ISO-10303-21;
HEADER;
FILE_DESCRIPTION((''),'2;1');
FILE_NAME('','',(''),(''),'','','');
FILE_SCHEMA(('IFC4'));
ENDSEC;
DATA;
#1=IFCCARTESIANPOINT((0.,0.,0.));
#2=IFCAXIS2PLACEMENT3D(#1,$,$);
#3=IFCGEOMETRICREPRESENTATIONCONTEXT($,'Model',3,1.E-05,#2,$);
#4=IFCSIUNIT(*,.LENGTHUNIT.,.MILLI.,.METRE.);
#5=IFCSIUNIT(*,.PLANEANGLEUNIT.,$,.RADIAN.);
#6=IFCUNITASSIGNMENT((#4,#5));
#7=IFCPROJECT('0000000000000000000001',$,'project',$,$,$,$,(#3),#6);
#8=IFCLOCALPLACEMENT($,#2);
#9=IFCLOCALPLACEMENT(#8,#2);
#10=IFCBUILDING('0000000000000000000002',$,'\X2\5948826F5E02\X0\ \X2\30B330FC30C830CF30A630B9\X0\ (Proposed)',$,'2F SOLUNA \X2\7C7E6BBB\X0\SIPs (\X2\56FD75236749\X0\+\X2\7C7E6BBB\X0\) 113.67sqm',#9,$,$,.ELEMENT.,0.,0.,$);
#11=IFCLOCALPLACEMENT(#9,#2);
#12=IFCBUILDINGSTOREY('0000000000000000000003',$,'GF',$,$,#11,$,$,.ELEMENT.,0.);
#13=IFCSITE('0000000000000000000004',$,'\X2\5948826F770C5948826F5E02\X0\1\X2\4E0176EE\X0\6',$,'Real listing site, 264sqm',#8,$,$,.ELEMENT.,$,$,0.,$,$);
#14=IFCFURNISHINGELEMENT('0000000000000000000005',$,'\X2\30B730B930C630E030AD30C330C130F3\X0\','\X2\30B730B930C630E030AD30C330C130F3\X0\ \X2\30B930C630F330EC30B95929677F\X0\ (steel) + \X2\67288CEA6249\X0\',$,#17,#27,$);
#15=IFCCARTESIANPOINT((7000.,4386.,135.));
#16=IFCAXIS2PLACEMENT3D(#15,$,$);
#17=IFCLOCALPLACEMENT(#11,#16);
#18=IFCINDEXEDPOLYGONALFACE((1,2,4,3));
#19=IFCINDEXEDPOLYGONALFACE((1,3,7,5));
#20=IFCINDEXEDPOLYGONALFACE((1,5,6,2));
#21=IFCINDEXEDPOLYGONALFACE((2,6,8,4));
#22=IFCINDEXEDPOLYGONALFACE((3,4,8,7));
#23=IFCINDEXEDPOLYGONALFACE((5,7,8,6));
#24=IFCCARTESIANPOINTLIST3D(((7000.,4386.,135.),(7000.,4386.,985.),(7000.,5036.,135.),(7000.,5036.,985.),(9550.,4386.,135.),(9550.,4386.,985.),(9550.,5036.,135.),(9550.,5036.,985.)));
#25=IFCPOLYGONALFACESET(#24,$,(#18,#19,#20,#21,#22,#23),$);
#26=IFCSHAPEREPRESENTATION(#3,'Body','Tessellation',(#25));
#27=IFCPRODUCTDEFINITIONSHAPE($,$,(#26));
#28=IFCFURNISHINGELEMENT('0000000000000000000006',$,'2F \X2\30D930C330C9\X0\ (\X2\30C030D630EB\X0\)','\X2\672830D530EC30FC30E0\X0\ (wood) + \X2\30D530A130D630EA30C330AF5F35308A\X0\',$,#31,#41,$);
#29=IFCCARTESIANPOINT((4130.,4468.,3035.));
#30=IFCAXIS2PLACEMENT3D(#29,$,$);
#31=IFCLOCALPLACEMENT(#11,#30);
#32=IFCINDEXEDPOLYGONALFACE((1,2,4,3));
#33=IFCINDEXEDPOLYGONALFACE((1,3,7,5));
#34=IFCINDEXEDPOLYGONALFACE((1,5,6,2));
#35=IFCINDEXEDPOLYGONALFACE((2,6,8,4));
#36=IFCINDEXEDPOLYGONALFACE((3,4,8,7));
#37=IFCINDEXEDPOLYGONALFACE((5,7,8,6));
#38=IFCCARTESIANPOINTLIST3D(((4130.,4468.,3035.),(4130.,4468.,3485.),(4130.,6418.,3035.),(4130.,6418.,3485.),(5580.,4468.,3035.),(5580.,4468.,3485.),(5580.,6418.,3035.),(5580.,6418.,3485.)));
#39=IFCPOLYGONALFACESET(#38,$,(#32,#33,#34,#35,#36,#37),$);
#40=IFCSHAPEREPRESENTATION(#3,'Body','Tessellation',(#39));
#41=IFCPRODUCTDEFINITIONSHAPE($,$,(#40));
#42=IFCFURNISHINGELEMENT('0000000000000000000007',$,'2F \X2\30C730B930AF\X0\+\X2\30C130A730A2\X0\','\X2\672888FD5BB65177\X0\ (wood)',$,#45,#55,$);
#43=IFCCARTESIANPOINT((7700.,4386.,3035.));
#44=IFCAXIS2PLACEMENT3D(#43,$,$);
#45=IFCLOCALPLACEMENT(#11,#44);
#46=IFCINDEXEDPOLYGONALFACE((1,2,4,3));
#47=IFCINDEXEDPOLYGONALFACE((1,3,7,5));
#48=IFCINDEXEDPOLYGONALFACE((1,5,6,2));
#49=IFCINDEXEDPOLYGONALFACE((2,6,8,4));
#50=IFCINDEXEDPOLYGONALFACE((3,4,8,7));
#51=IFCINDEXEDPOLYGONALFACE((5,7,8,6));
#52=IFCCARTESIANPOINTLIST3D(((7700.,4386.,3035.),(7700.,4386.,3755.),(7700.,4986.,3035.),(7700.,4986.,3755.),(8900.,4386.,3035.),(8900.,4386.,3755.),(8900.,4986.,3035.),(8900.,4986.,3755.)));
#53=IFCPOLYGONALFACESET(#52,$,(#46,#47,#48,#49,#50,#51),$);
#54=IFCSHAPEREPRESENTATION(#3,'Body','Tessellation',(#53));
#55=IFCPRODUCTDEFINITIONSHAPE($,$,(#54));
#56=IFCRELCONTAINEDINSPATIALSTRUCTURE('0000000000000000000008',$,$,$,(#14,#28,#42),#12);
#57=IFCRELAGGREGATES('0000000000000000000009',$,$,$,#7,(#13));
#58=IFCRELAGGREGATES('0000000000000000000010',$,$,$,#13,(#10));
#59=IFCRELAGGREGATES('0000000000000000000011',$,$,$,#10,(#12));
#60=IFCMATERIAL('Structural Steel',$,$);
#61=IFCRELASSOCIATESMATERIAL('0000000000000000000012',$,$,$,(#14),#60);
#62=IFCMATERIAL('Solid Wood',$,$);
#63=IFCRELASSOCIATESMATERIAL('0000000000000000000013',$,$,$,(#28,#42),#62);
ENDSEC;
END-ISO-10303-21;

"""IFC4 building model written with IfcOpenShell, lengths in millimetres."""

from ifc_helpers import new_model, si_unit, frame, frame_2d, origin, place, context, project, spatial, rectangle, extrude, material, element, save


model = new_model("IFC4")

# Units and contexts
model_context = context("Model", 3, precision=1e-05, world=origin())
ifc_project = project(units=[si_unit("LENGTHUNIT", "METRE", prefix="MILLI"), si_unit("PLANEANGLEUNIT", "RADIAN")], contexts=[model_context])

# Site, building, storey
site_placement = place(None, origin())
site = spatial("IfcSite", under=ifc_project, at=site_placement, Name="奈良県奈良市1丁目6", ObjectType="Real listing site, 264sqm", CompositionType="ELEMENT", RefElevation=0.0)
building_placement = place(site_placement, origin())
building = spatial("IfcBuilding", under=site, at=building_placement, Name="奈良市 コートハウス (Proposed)", ObjectType="2F SOLUNA 籾殻SIPs (国産杉+籾殻) 113.67sqm", CompositionType="ELEMENT", ElevationOfRefHeight=0.0, ElevationOfTerrain=0.0)
storey_placement = place(building_placement, origin())
storey = spatial("IfcBuildingStorey", under=building, at=storey_placement, Name="GF", CompositionType="ELEMENT", Elevation=0.0)

# Shared definitions
ifc_material_1 = material(Name="Solid Wood")

# Furnishing elements
ifc_material_2 = material(Name="Structural Steel")
furnishing_1_placement = place(storey_placement, frame((7000.0, 4386.0, 135.0)))
element("IfcFurnishingElement", 1, at=furnishing_1_placement, inside=storey, material=ifc_material_2, Name="システムキッチン", Description="システムキッチン ステンレス天板 (steel) + 木質扉", context=model_context, shape_type="SweptSolid", body=[
    extrude(rectangle(XDim=2550.0, YDim=650.0, at=frame_2d((1275.0, 325.0))), frame((7000.0, 4386.0, 135.0)), (0.0, 0.0, 1.0), 850.0),
])
furnishing_2_placement = place(storey_placement, frame((4130.0, 4468.0, 3035.0)))
element("IfcFurnishingElement", 2, at=furnishing_2_placement, inside=storey, material=ifc_material_1, Name="2F ベッド (ダブル)", Description="木フレーム (wood) + ファブリック張り", context=model_context, shape_type="SweptSolid", body=[
    extrude(rectangle(XDim=1450.0, YDim=1950.0, at=frame_2d((725.0, 975.0))), frame((4130.0, 4468.0, 3035.0)), (0.0, 0.0, 1.0), 450.0),
])
furnishing_3_placement = place(storey_placement, frame((7700.0, 4386.0, 3035.0)))
element("IfcFurnishingElement", 3, at=furnishing_3_placement, inside=storey, material=ifc_material_1, Name="2F デスク+チェア", Description="木製家具 (wood)", context=model_context, shape_type="SweptSolid", body=[
    extrude(rectangle(XDim=1200.0, YDim=600.0, at=frame_2d((600.0, 300.0))), frame((7700.0, 4386.0, 3035.0)), (0.0, 0.0, 1.0), 720.0),
])

save(model, "model.ifc")
